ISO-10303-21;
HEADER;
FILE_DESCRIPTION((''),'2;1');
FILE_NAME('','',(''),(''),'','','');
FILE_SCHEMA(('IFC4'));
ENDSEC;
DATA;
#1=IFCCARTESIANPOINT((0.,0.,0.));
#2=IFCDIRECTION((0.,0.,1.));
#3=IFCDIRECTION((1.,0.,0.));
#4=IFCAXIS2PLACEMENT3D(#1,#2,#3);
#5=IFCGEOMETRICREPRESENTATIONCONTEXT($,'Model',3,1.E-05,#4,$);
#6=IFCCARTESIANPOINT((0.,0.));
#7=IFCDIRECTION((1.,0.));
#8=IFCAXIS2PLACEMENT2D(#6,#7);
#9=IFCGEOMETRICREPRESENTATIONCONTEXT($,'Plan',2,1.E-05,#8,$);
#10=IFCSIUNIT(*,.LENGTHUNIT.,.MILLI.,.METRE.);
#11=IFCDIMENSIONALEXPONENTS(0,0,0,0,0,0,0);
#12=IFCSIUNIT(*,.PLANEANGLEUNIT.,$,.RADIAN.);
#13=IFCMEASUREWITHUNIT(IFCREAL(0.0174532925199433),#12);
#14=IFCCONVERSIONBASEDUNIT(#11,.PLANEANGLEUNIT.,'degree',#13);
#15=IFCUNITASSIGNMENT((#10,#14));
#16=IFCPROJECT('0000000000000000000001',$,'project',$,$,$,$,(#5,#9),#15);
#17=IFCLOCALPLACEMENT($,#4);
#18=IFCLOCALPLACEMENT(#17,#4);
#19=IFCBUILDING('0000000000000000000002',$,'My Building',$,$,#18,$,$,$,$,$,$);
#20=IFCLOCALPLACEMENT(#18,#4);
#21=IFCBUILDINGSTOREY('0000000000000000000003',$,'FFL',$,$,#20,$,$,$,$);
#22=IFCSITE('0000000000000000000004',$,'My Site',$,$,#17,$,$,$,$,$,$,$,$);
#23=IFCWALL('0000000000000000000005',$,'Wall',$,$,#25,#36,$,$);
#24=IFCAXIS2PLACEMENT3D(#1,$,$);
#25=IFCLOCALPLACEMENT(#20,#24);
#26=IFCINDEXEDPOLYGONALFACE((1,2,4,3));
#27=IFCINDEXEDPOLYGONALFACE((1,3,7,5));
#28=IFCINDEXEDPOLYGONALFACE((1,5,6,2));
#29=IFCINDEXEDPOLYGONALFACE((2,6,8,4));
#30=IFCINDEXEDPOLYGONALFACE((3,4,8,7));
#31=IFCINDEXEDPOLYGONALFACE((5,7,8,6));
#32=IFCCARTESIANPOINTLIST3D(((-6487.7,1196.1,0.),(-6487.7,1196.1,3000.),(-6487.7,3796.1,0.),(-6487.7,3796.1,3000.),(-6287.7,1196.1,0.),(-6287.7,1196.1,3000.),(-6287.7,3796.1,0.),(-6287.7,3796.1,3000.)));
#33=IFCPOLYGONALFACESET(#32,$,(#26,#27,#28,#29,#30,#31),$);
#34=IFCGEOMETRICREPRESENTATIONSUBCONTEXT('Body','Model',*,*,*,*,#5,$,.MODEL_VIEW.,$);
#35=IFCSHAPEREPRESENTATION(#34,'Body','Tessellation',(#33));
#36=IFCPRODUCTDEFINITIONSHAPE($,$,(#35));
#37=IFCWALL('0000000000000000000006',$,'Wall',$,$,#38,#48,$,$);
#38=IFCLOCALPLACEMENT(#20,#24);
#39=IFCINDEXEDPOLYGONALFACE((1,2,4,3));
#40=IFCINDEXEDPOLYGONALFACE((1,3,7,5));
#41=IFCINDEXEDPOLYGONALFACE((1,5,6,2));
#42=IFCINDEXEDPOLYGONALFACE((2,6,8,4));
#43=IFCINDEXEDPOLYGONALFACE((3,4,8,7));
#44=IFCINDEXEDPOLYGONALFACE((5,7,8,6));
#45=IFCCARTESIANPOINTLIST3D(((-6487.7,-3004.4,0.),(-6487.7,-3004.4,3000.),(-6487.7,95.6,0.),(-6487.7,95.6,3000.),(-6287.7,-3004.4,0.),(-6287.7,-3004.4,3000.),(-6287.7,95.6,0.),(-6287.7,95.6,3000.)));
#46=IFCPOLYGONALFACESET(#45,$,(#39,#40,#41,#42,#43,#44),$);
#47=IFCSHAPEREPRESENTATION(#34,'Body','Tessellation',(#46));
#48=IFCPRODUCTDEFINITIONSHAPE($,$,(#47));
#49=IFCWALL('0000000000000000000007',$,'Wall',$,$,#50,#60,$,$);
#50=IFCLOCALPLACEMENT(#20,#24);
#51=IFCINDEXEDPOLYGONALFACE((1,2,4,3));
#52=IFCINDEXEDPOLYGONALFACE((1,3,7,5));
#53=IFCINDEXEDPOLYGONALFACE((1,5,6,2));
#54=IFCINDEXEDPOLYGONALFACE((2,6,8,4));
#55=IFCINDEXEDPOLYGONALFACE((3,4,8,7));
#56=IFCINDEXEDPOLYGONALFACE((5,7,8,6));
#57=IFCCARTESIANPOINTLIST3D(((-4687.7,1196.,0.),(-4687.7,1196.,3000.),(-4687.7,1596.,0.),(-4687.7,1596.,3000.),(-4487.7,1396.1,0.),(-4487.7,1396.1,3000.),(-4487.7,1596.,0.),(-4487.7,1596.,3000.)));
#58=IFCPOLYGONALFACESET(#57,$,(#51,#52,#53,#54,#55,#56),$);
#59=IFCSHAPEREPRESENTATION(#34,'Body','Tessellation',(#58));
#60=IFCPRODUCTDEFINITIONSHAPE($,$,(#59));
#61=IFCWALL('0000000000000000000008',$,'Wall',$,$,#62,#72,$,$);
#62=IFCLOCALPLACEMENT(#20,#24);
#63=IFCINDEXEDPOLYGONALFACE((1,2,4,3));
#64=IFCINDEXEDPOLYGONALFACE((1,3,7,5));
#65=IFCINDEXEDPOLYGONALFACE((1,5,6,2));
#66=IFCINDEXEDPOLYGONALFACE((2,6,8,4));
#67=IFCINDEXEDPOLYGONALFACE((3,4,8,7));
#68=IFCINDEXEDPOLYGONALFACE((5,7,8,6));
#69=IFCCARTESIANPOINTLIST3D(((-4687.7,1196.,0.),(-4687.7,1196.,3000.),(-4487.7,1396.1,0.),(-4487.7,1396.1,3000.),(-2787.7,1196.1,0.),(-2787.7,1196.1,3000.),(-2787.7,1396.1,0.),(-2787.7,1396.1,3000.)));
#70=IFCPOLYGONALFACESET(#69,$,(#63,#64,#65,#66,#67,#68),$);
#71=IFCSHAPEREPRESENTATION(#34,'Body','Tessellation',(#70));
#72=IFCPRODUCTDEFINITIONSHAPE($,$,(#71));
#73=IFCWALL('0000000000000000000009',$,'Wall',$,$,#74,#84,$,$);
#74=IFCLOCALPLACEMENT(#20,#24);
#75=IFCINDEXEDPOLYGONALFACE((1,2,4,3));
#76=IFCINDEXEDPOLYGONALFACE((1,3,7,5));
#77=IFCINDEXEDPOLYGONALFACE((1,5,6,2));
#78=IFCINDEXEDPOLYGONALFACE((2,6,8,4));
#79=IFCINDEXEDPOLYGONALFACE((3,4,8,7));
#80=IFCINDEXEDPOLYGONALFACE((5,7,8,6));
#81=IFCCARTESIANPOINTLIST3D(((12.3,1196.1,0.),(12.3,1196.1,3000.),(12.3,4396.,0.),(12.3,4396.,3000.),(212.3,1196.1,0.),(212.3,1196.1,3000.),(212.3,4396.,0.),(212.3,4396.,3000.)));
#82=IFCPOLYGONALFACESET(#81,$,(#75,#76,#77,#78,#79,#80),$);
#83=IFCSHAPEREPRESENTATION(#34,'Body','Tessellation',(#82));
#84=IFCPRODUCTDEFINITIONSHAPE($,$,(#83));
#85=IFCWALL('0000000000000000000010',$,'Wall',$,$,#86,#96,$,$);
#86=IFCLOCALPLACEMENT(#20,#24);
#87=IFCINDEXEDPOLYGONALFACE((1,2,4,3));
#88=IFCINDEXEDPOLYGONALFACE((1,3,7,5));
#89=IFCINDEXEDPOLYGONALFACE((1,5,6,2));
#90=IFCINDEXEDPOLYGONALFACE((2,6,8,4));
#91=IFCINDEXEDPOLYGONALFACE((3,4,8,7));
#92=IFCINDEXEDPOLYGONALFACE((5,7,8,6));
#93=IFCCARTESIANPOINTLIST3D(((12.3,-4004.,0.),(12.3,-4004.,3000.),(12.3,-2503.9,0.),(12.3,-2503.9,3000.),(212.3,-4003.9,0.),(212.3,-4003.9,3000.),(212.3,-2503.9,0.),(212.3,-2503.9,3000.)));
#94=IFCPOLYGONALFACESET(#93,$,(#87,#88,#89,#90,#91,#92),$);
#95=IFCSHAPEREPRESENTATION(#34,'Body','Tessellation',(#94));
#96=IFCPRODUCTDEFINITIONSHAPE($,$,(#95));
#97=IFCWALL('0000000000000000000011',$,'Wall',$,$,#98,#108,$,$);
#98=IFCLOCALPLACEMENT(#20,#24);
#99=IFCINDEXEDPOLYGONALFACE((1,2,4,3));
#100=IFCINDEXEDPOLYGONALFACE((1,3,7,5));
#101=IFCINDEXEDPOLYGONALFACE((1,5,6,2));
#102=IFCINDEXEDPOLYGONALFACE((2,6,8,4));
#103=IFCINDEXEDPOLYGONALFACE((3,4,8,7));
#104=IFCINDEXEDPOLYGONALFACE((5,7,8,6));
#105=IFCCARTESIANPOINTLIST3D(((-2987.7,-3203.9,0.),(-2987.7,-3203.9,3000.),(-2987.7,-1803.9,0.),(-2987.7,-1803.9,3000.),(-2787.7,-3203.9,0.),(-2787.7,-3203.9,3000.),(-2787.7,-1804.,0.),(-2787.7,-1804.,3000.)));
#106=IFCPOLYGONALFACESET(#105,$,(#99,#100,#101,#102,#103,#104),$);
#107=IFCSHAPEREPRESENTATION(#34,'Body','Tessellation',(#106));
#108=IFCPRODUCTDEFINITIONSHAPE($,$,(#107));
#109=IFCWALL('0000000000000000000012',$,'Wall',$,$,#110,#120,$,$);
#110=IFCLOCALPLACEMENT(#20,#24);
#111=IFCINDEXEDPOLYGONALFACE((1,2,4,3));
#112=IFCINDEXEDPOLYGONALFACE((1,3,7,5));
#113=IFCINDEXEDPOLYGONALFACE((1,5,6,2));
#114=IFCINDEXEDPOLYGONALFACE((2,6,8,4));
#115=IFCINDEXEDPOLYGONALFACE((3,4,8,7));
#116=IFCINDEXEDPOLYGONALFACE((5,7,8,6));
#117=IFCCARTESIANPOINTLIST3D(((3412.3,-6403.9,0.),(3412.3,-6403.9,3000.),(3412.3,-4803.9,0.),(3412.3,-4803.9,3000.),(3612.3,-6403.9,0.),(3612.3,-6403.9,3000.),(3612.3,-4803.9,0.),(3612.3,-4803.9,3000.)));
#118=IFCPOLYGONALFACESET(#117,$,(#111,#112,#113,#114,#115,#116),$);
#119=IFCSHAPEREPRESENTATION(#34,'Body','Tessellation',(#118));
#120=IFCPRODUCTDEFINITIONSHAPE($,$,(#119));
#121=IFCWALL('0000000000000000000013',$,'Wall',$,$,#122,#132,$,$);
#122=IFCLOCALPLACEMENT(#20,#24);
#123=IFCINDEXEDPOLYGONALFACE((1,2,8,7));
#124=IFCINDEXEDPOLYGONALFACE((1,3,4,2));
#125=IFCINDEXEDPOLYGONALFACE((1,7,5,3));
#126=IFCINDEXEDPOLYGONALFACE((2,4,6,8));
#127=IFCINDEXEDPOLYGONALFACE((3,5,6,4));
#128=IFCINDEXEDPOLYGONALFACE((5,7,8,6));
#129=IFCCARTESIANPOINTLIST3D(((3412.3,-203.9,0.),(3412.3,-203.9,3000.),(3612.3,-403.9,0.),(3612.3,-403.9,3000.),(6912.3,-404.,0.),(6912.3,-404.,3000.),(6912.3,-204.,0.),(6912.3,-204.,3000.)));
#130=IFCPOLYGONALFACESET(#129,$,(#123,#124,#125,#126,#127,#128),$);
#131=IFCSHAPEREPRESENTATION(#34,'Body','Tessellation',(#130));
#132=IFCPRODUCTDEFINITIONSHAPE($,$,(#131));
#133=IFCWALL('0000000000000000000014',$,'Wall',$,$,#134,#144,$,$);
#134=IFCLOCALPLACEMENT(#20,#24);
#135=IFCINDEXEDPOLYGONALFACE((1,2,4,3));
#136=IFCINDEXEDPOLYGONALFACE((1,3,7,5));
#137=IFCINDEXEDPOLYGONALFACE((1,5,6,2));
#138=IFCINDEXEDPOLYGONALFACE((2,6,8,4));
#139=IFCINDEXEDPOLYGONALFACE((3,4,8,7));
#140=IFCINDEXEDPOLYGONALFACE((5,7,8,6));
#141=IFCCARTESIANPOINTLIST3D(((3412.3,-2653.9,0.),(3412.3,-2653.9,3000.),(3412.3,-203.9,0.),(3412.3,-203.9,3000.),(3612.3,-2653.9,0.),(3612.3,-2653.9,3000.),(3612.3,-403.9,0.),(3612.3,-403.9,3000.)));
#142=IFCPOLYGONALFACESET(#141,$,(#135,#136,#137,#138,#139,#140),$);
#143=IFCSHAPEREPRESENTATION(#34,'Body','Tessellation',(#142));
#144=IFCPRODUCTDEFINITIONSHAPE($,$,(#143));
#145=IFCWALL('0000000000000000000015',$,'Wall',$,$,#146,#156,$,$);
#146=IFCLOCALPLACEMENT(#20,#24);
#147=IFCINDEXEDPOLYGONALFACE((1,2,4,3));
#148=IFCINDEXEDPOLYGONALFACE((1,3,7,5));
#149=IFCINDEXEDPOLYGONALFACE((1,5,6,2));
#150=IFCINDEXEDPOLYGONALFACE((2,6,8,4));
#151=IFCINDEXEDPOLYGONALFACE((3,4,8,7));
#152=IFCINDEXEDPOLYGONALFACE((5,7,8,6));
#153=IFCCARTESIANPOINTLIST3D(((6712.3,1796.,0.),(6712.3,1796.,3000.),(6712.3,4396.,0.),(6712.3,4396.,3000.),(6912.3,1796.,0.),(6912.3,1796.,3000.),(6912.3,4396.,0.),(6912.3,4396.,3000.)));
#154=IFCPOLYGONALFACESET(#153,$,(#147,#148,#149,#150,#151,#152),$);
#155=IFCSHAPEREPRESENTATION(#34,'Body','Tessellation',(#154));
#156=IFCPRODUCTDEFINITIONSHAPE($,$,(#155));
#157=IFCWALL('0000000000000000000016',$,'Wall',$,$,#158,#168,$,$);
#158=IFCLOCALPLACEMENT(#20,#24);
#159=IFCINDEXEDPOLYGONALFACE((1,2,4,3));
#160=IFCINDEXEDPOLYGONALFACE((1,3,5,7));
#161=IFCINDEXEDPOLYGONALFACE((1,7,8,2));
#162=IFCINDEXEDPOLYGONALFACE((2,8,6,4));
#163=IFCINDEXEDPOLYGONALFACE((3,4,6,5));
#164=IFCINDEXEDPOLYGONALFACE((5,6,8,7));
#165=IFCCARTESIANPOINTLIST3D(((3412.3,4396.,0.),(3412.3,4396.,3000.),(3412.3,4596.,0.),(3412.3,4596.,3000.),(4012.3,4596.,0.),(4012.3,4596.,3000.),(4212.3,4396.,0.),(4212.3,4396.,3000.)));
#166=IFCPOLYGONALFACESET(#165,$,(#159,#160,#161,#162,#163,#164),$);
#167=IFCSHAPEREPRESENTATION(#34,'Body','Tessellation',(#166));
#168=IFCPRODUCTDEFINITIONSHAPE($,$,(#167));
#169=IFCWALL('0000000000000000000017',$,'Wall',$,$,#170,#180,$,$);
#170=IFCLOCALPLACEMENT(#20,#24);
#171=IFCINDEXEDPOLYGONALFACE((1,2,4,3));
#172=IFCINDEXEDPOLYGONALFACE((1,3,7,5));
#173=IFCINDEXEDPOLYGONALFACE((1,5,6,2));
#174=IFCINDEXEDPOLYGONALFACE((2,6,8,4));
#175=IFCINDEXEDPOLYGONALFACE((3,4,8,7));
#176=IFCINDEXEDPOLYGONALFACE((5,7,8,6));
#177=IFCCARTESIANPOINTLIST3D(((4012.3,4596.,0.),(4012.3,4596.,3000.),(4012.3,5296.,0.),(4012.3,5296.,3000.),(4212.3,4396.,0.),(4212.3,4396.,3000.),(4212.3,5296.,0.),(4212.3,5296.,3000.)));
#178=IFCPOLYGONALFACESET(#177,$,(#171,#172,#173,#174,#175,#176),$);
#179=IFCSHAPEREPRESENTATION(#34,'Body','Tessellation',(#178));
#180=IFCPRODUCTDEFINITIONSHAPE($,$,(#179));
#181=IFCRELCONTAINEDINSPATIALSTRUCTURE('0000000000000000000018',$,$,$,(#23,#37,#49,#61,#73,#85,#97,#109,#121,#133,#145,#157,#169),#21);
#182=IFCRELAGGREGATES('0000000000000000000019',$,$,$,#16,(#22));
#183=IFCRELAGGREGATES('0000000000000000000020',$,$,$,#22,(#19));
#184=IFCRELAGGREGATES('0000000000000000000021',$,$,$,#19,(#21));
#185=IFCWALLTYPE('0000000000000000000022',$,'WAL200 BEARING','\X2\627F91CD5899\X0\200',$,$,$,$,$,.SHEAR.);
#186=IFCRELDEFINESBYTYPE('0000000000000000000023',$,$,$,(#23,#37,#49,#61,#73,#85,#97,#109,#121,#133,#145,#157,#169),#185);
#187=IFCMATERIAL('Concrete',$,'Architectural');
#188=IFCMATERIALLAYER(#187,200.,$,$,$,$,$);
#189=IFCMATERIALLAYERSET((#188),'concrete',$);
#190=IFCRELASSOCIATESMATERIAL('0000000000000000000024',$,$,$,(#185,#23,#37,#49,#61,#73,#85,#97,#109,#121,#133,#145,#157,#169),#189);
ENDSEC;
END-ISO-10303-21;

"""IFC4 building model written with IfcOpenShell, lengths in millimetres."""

from ifc_helpers import new_model, entity, si_unit, converted_unit, frame, origin_with_axes, origin_2d_with_axis, place, context, subcontext, project, spatial, line, indexed_curve, outline, extrude, material, layer, layer_set, layer_usage, type_object, element, save


model = new_model("IFC4")

# Units and contexts
model_context = context("Model", 3, precision=1e-05, world=origin_with_axes())
plan_context = context("Plan", 2, precision=1e-05, world=origin_2d_with_axis())
body_context = subcontext(model_context, "Body", "Model", "MODEL_VIEW")
ifc_project = project(units=[si_unit("LENGTHUNIT", "METRE", prefix="MILLI"), converted_unit("PLANEANGLEUNIT", "degree", entity("IfcReal", 0.0174532925199433), si_unit("PLANEANGLEUNIT", "RADIAN"), dimensions=[0, 0, 0, 0, 0, 0, 0])], contexts=[model_context, plan_context])

# Site, building, storey
site_placement = place(None, origin_with_axes())
site = spatial("IfcSite", under=ifc_project, at=site_placement, Name="My Site")
building_placement = place(site_placement, origin_with_axes())
building = spatial("IfcBuilding", under=site, at=building_placement, Name="My Building")
storey_placement = place(building_placement, origin_with_axes())
storey = spatial("IfcBuildingStorey", under=building, at=storey_placement, Name="FFL")

# Walls
ifc_material_1 = material(Name="Concrete", Category="Architectural")
ifc_layer_1 = layer(ifc_material_1, 200.0)
ifc_layer_set_1 = layer_set([ifc_layer_1], Name="concrete")
ifc_layer_usage_1 = layer_usage(ifc_layer_set_1, "AXIS2", "POSITIVE", 0.0)
wall_type_1 = type_object("IfcWallType", Name="WAL200 BEARING", Description="承重墙200", PredefinedType="SHEAR", material=ifc_layer_set_1)
wall_1_placement = place(storey_placement, frame((-6287.7, 1196.1, 0.0), z_axis=(0.0, 0.0, 1.0), x_axis=(0.0, 1.0, 0.0)))
element("IfcWall", 1, at=wall_1_placement, inside=storey, type_object=wall_type_1, material=ifc_layer_usage_1, Name="Wall", context=body_context, shape_type="SweptSolid", body=[
    extrude(outline(indexed_curve([(0.0, 0.0), (0.0, 200.0), (2600.0, 200.0), (2600.0, 0.0)], segments=[line(1, 2, 3, 4, 1)])), origin_with_axes(), (0.0, 0.0, 1.0), 3000.0),
])
ifc_layer_usage_2 = layer_usage(ifc_layer_set_1, "AXIS2", "POSITIVE", 0.0)
wall_2_placement = place(storey_placement, frame((-6487.7, 95.6, 0.0), z_axis=(0.0, 0.0, 1.0), x_axis=(0.0, -1.0, 0.0)))
element("IfcWall", 2, at=wall_2_placement, inside=storey, type_object=wall_type_1, material=ifc_layer_usage_2, Name="Wall", context=body_context, shape_type="SweptSolid", body=[
    extrude(outline(indexed_curve([(0.0, 0.0), (0.0, 200.0), (3100.0, 200.0), (3100.0, 0.0)], segments=[line(1, 2, 3, 4, 1)])), origin_with_axes(), (0.0, 0.0, 1.0), 3000.0),
])
ifc_layer_usage_3 = layer_usage(ifc_layer_set_1, "AXIS2", "POSITIVE", 0.0)
wall_3_placement = place(storey_placement, frame((-4687.7, 1596.0, 0.0), z_axis=(0.0, 0.0, 1.0), x_axis=(0.0, -1.0, 0.0)))
element("IfcWall", 3, at=wall_3_placement, inside=storey, type_object=wall_type_1, material=ifc_layer_usage_3, Name="Wall", context=body_context, shape_type="SweptSolid", body=[
    extrude(outline(indexed_curve([(0.0, 0.0), (0.0, 200.0), (200.0, 200.0), (400.0, 0.0)], segments=[line(1, 2, 3, 4, 1)])), origin_with_axes(), (0.0, 0.0, 1.0), 3000.0),
])
ifc_layer_usage_4 = layer_usage(ifc_layer_set_1, "AXIS2", "POSITIVE", 0.0)
wall_4_placement = place(storey_placement, frame((-4687.7, 1196.0, 0.0), z_axis=(0.0, 0.0, 1.0), x_axis=(1.0, 0.000001, 0.0)))
element("IfcWall", 4, at=wall_4_placement, inside=storey, type_object=wall_type_1, material=ifc_layer_usage_4, Name="Wall", context=body_context, shape_type="SweptSolid", body=[
    extrude(outline(indexed_curve([(0.0, 0.0), (200.0, 200.0), (1900.0, 200.0), (1900.0, 0.0)], segments=[line(1, 2, 3, 4, 1)])), origin_with_axes(), (0.0, 0.0, 1.0), 3000.0),
])
ifc_layer_usage_5 = layer_usage(ifc_layer_set_1, "AXIS2", "POSITIVE", 0.0)
wall_5_placement = place(storey_placement, frame((12.3, 4396.0, 0.0), z_axis=(0.0, 0.0, 1.0), x_axis=(0.0, -1.0, 0.0)))
element("IfcWall", 5, at=wall_5_placement, inside=storey, type_object=wall_type_1, material=ifc_layer_usage_5, Name="Wall", context=body_context, shape_type="SweptSolid", body=[
    extrude(outline(indexed_curve([(0.0, 0.0), (0.0, 200.0), (3200.0, 200.0), (3200.0, 0.0)], segments=[line(1, 2, 3, 4, 1)])), origin_with_axes(), (0.0, 0.0, 1.0), 3000.0),
])
ifc_layer_usage_6 = layer_usage(ifc_layer_set_1, "AXIS2", "POSITIVE", 0.0)
wall_6_placement = place(storey_placement, frame((212.3, -4003.9, 0.0), z_axis=(0.0, 0.0, 1.0), x_axis=(-0.000008, 1.0, 0.0)))
element("IfcWall", 6, at=wall_6_placement, inside=storey, type_object=wall_type_1, material=ifc_layer_usage_6, Name="Wall", context=body_context, shape_type="SweptSolid", body=[
    extrude(outline(indexed_curve([(0.0, 0.0), (0.0, 200.0), (1500.0, 200.0), (1500.0, 0.0)], segments=[line(1, 2, 3, 4, 1)])), origin_with_axes(), (0.0, 0.0, 1.0), 3000.0),
])
ifc_layer_usage_7 = layer_usage(ifc_layer_set_1, "AXIS2", "POSITIVE", 0.0)
wall_7_placement = place(storey_placement, frame((-2987.7, -1803.9, 0.0), z_axis=(0.0, 0.0, 1.0), x_axis=(-0.000007, -1.0, 0.0)))
element("IfcWall", 7, at=wall_7_placement, inside=storey, type_object=wall_type_1, material=ifc_layer_usage_7, Name="Wall", context=body_context, shape_type="SweptSolid", body=[
    extrude(outline(indexed_curve([(0.0, 0.0), (0.0, 200.0), (1400.0, 200.0), (1400.0, 0.0)], segments=[line(1, 2, 3, 4, 1)])), origin_with_axes(), (0.0, 0.0, 1.0), 3000.0),
])
ifc_layer_usage_8 = layer_usage(ifc_layer_set_1, "AXIS2", "POSITIVE", 0.0)
wall_8_placement = place(storey_placement, frame((3412.3, -4803.9, 0.0), z_axis=(0.0, 0.0, 1.0), x_axis=(0.0, -1.0, 0.0)))
element("IfcWall", 8, at=wall_8_placement, inside=storey, type_object=wall_type_1, material=ifc_layer_usage_8, Name="Wall", context=body_context, shape_type="SweptSolid", body=[
    extrude(outline(indexed_curve([(0.0, 0.0), (0.0, 200.0), (1600.0, 200.0), (1600.0, 0.0)], segments=[line(1, 2, 3, 4, 1)])), origin_with_axes(), (0.0, 0.0, 1.0), 3000.0),
])
ifc_layer_usage_9 = layer_usage(ifc_layer_set_1, "AXIS2", "POSITIVE", 0.0)
wall_9_placement = place(storey_placement, frame((6912.3, -204.0, 0.0), z_axis=(0.0, 0.0, 1.0), x_axis=(-1.0, 0.000006, 0.0)))
element("IfcWall", 9, at=wall_9_placement, inside=storey, type_object=wall_type_1, material=ifc_layer_usage_9, Name="Wall", context=body_context, shape_type="SweptSolid", body=[
    extrude(outline(indexed_curve([(0.0, 0.0), (0.0, 200.0), (3300.0, 200.0), (3500.0, 0.0)], segments=[line(1, 2, 3, 4, 1)])), origin_with_axes(), (0.0, 0.0, 1.0), 3000.0),
])
ifc_layer_usage_10 = layer_usage(ifc_layer_set_1, "AXIS2", "POSITIVE", 0.0)
wall_10_placement = place(storey_placement, frame((3412.3, -203.9, 0.0), z_axis=(0.0, 0.0, 1.0), x_axis=(0.0, -1.0, 0.0)))
element("IfcWall", 10, at=wall_10_placement, inside=storey, type_object=wall_type_1, material=ifc_layer_usage_10, Name="Wall", context=body_context, shape_type="SweptSolid", body=[
    extrude(outline(indexed_curve([(0.0, 0.0), (200.0, 200.0), (2450.0, 200.0), (2450.0, 0.0)], segments=[line(1, 2, 3, 4, 1)])), origin_with_axes(), (0.0, 0.0, 1.0), 3000.0),
])
ifc_layer_usage_11 = layer_usage(ifc_layer_set_1, "AXIS2", "POSITIVE", 0.0)
wall_11_placement = place(storey_placement, frame((6712.3, 4396.0, 0.0), z_axis=(0.0, 0.0, 1.0), x_axis=(0.0, -1.0, 0.0)))
element("IfcWall", 11, at=wall_11_placement, inside=storey, type_object=wall_type_1, material=ifc_layer_usage_11, Name="Wall", context=body_context, shape_type="SweptSolid", body=[
    extrude(outline(indexed_curve([(0.0, 0.0), (0.0, 200.0), (2600.0, 200.0), (2600.0, 0.0)], segments=[line(1, 2, 3, 4, 1)])), origin_with_axes(), (0.0, 0.0, 1.0), 3000.0),
])
ifc_layer_usage_12 = layer_usage(ifc_layer_set_1, "AXIS2", "POSITIVE", 0.0)
wall_12_placement = place(storey_placement, frame((3412.3, 4396.0, 0.0), z_axis=(0.0, 0.0, 1.0), x_axis=(1.0, 0.0, 0.0)))
element("IfcWall", 12, at=wall_12_placement, inside=storey, type_object=wall_type_1, material=ifc_layer_usage_12, Name="Wall", context=body_context, shape_type="SweptSolid", body=[
    extrude(outline(indexed_curve([(0.0, 0.0), (0.0, 200.0), (600.0, 200.0), (800.0, 0.0)], segments=[line(1, 2, 3, 4, 1)])), origin_with_axes(), (0.0, 0.0, 1.0), 3000.0),
])
ifc_layer_usage_13 = layer_usage(ifc_layer_set_1, "AXIS2", "POSITIVE", 0.0)
wall_13_placement = place(storey_placement, frame((4212.3, 4396.0, 0.0), z_axis=(0.0, 0.0, 1.0), x_axis=(0.0, 1.0, 0.0)))
element("IfcWall", 13, at=wall_13_placement, inside=storey, type_object=wall_type_1, material=ifc_layer_usage_13, Name="Wall", context=body_context, shape_type="SweptSolid", body=[
    extrude(outline(indexed_curve([(0.0, 0.0), (200.0, 200.0), (900.0, 200.0), (900.0, 0.0)], segments=[line(1, 2, 3, 4, 1)])), origin_with_axes(), (0.0, 0.0, 1.0), 3000.0),
])

save(model, "model.ifc")
